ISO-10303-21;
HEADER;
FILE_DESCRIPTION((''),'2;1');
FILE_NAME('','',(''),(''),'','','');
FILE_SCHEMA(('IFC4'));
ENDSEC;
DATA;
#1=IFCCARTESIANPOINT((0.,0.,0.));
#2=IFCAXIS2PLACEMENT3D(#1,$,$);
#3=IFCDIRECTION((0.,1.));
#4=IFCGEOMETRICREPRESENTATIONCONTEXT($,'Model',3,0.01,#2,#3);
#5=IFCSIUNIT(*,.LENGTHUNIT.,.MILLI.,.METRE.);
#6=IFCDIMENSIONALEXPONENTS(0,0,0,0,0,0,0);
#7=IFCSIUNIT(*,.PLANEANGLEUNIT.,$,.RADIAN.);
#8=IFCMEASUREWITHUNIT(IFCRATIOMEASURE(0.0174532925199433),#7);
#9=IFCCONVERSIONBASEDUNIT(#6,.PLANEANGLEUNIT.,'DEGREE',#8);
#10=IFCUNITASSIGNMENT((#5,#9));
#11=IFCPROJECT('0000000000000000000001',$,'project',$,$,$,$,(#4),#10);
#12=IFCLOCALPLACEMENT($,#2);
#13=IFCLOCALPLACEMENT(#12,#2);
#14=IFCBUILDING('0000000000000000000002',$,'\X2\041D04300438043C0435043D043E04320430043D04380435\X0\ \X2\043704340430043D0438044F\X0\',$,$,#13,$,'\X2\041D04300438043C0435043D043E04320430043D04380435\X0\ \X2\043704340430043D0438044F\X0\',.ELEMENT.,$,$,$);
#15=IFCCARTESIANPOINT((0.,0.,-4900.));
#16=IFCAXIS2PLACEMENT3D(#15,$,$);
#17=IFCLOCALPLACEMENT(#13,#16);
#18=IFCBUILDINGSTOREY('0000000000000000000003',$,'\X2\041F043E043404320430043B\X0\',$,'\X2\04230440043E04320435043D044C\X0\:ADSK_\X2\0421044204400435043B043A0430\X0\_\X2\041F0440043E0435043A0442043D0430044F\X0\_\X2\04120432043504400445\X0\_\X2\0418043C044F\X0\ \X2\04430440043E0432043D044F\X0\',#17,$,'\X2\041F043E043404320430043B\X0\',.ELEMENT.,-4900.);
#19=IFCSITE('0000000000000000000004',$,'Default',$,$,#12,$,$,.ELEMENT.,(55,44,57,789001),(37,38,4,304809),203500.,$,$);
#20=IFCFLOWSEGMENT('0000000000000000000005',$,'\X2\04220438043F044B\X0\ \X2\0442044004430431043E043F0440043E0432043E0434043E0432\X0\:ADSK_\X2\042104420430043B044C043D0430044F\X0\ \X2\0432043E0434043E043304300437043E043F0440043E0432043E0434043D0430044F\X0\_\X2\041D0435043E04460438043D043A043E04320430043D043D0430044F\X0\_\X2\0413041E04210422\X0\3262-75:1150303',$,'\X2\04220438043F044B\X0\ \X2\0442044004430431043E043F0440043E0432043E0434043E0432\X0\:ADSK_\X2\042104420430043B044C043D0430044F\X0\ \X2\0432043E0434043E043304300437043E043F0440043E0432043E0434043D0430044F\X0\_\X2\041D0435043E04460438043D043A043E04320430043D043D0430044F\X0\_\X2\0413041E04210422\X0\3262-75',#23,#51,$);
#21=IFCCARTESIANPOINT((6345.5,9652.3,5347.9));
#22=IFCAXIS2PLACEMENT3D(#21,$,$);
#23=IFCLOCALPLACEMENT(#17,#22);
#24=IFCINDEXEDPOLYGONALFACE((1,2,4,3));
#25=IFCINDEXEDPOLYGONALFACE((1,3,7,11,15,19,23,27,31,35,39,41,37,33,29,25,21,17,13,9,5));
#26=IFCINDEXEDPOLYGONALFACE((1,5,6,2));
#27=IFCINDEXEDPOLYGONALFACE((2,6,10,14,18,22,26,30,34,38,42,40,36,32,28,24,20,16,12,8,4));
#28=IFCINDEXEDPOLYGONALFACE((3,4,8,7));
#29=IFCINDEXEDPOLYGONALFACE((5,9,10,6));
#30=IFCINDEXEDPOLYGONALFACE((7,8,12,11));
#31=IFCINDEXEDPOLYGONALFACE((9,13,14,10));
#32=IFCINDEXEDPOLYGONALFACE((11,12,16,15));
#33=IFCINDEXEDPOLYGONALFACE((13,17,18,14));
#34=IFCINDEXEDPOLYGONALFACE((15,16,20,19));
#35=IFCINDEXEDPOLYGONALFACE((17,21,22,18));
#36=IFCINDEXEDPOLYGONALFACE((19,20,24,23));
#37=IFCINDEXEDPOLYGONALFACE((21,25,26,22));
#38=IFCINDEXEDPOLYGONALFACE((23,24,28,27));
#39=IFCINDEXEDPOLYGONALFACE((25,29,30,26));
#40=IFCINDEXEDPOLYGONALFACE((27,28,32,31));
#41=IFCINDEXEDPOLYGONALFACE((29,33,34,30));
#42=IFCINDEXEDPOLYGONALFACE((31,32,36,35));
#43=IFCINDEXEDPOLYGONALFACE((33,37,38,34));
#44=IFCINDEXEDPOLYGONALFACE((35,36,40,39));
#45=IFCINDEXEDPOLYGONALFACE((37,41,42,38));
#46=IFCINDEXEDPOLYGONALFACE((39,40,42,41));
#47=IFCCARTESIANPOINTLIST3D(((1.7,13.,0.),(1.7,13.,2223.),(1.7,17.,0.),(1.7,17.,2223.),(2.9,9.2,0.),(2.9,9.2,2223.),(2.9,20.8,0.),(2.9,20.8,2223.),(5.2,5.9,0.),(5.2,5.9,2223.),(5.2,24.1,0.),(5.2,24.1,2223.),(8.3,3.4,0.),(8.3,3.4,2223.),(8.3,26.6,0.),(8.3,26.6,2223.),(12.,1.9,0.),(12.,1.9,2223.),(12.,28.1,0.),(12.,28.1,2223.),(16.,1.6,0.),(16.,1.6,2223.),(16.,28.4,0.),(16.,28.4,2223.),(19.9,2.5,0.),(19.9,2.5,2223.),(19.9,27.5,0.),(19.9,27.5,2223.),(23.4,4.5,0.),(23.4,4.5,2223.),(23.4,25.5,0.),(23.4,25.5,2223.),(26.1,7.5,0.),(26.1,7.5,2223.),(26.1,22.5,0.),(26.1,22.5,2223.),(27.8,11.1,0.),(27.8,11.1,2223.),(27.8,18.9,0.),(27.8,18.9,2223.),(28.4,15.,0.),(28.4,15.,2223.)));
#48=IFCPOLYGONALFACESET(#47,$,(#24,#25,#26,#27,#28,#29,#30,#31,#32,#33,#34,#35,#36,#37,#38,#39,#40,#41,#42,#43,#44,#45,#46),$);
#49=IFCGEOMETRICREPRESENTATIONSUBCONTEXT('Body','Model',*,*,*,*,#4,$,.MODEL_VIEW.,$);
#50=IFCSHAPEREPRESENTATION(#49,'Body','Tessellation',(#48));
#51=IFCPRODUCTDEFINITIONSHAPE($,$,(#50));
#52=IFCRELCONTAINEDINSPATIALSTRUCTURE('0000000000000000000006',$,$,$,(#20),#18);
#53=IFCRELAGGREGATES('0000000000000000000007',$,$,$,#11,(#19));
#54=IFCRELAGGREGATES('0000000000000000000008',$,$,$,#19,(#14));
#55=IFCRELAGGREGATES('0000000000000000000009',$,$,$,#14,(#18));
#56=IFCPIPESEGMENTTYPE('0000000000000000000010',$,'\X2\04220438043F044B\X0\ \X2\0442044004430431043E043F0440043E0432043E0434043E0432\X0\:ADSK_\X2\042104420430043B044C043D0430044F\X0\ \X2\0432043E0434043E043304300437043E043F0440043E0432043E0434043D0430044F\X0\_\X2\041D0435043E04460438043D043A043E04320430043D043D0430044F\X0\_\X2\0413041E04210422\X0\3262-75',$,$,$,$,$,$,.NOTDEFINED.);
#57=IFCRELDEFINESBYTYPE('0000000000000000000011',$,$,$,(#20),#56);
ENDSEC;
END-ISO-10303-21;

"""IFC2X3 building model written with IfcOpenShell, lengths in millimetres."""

from ifc_helpers import new_model, entity, si_unit, converted_unit, direction, frame, origin, origin_2d_with_axis, place, context, subcontext, project, spatial, circle, extrude, type_object, element, save


model = new_model("IFC2X3")

# Units and contexts
model_context = context("Model", 3, precision=0.01, world=origin(), true_north=direction((0.0, 1.0)))
body_context = subcontext(model_context, "Body", "Model", "MODEL_VIEW")
ifc_project = project(units=[si_unit("LENGTHUNIT", "METRE", prefix="MILLI"), converted_unit("PLANEANGLEUNIT", "DEGREE", entity("IfcRatioMeasure", 0.0174532925199433), si_unit("PLANEANGLEUNIT", "RADIAN"), dimensions=[0, 0, 0, 0, 0, 0, 0])], contexts=[model_context])

# Site, building, storey
site_placement = place(None, origin())
site = spatial("IfcSite", under=ifc_project, at=site_placement, Name="Default", CompositionType="ELEMENT", RefLatitude=(55, 44, 57, 789001), RefLongitude=(37, 38, 4, 304809), RefElevation=203500.0)
building_placement = place(site_placement, origin())
building = spatial("IfcBuilding", under=site, at=building_placement, Name="Наименование здания", LongName="Наименование здания", CompositionType="ELEMENT")
storey_placement = place(building_placement, frame((0.0, 0.0, -4900.0)))
storey = spatial("IfcBuildingStorey", under=building, at=storey_placement, Name="Подвал", ObjectType="Уровень:ADSK_Стрелка_Проектная_Вверх_Имя уровня", LongName="Подвал", CompositionType="ELEMENT", Elevation=-4900.0)

# Flow segment
pipe_segment_type = type_object("IfcPipeSegmentType", Name="Типы трубопроводов:ADSK_Стальная водогазопроводная_Неоцинкованная_ГОСТ3262-75", PredefinedType="NOTDEFINED")
flow_segment_1_placement = place(storey_placement, frame((6345.5, 9652.3, 5347.9)))
element("IfcFlowSegment", 1, at=flow_segment_1_placement, inside=storey, type_object=pipe_segment_type, Name="Типы трубопроводов:ADSK_Стальная водогазопроводная_Неоцинкованная_ГОСТ3262-75:1150303", ObjectType="Типы трубопроводов:ADSK_Стальная водогазопроводная_Неоцинкованная_ГОСТ3262-75", context=body_context, shape_type="SweptSolid", body=[
    extrude(circle(Radius=13.4, at=origin_2d_with_axis()), frame((15.0, 15.0, 0.0)), (0.0, 0.0, 1.0), 2223.0),
])

save(model, "model.ifc")
